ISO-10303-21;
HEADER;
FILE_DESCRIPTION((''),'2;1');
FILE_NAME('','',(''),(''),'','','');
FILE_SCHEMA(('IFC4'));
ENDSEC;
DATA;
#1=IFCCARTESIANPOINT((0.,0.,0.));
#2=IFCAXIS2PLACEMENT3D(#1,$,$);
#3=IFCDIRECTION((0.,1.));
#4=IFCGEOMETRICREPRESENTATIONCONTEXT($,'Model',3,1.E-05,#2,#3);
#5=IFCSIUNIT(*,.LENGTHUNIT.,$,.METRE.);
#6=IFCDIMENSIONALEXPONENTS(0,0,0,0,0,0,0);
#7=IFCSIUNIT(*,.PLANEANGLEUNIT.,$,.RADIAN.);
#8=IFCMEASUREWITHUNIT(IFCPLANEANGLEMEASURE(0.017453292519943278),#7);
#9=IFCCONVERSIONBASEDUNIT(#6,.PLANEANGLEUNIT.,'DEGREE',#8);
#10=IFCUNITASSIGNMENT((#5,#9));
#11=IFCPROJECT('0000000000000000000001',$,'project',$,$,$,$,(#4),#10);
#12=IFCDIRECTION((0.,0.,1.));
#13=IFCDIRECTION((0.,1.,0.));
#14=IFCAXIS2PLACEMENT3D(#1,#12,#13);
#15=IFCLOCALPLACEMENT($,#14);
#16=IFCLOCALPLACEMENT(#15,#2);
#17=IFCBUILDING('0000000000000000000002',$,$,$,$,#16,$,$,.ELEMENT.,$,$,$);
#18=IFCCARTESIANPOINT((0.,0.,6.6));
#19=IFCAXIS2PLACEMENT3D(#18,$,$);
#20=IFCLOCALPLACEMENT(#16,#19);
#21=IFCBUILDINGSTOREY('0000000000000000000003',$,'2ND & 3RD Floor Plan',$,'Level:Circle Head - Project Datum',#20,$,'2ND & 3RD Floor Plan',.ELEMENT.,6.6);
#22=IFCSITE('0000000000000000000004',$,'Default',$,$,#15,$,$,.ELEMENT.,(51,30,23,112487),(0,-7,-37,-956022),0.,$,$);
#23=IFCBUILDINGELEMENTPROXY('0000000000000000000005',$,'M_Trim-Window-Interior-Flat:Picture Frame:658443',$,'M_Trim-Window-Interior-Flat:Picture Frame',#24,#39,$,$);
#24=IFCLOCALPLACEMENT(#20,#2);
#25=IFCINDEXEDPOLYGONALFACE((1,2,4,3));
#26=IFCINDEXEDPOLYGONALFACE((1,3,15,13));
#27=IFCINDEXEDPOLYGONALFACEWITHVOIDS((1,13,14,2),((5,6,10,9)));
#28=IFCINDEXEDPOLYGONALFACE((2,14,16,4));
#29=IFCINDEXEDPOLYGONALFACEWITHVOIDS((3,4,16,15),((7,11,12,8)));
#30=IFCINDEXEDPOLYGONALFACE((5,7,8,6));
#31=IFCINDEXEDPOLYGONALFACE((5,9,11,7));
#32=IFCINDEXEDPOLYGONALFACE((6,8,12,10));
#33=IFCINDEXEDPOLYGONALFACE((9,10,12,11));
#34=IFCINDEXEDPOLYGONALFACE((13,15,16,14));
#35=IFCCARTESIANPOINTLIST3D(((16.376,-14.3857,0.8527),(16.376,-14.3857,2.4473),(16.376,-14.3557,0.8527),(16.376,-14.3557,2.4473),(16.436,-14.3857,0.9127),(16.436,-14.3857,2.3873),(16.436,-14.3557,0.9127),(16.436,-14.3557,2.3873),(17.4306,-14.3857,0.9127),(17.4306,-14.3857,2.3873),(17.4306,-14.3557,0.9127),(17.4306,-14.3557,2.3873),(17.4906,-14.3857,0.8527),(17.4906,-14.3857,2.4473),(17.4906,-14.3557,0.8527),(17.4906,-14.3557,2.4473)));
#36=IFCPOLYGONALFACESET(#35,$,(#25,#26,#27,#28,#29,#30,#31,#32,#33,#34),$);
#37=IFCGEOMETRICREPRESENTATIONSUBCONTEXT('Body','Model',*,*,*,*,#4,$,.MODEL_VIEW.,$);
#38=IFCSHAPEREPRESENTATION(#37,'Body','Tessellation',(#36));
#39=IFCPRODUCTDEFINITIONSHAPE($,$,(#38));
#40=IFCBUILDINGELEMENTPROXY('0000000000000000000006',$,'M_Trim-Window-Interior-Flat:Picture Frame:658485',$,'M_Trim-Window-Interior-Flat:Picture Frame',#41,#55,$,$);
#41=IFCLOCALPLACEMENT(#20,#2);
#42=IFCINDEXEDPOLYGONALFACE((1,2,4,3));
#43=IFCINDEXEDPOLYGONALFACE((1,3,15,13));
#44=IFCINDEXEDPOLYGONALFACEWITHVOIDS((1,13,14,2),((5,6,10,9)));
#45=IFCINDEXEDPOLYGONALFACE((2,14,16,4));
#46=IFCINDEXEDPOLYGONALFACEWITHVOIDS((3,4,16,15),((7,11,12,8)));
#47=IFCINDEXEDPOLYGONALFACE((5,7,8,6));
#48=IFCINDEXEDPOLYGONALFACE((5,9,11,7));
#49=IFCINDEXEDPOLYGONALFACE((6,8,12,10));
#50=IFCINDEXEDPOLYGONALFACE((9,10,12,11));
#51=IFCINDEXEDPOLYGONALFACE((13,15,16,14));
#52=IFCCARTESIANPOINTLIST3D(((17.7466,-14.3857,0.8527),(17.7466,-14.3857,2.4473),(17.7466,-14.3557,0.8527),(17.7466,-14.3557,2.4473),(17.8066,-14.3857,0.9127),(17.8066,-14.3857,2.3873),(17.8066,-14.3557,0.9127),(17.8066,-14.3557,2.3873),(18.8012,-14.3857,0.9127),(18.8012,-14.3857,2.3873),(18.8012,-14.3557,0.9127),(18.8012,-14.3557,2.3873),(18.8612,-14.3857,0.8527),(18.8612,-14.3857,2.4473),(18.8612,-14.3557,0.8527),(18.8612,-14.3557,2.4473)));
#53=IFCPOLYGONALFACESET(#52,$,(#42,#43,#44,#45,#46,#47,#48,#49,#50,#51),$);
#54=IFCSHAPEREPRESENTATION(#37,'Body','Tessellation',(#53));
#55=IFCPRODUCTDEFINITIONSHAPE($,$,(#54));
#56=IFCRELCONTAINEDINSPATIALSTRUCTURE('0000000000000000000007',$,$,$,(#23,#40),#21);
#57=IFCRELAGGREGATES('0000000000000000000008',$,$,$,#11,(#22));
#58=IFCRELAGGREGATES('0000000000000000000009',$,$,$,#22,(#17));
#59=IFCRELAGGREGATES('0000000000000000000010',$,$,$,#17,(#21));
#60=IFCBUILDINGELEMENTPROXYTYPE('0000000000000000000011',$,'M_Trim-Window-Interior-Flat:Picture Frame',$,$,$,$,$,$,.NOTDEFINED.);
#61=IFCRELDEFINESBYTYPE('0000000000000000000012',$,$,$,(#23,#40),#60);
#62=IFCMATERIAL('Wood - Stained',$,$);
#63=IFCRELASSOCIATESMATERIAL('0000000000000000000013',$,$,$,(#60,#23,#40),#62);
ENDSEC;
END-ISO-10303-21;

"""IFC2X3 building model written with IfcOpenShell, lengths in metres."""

from ifc_helpers import new_model, entity, si_unit, converted_unit, direction, frame, origin, place, context, subcontext, project, spatial, polyline, outline, extrude, source, transform, mapped, material, type_object, type_shapes, element, save


model = new_model("IFC2X3")

# Units and contexts
model_context = context("Model", 3, precision=1e-05, world=origin(), true_north=direction((0.0, 1.0)))
body_context = subcontext(model_context, "Body", "Model", "MODEL_VIEW")
ifc_project = project(units=[si_unit("LENGTHUNIT", "METRE"), converted_unit("PLANEANGLEUNIT", "DEGREE", entity("IfcPlaneAngleMeasure", 0.017453292519943278), si_unit("PLANEANGLEUNIT", "RADIAN"), dimensions=[0, 0, 0, 0, 0, 0, 0])], contexts=[model_context])

# Site, building, storey
site_placement = place(None, frame((0.0, 0.0, 0.0), z_axis=(0.0, 0.0, 1.0), x_axis=(0.0, 1.0, 0.0)))
site = spatial("IfcSite", under=ifc_project, at=site_placement, Name="Default", CompositionType="ELEMENT", RefLatitude=(51, 30, 23, 112487), RefLongitude=(0, -7, -37, -956022), RefElevation=0.0)
building_placement = place(site_placement, origin())
building = spatial("IfcBuilding", under=site, at=building_placement, CompositionType="ELEMENT")
storey_placement = place(building_placement, frame((0.0, 0.0, 6.6)))
storey = spatial("IfcBuildingStorey", under=building, at=storey_placement, Name="2ND & 3RD Floor Plan", ObjectType="Level:Circle Head - Project Datum", LongName="2ND & 3RD Floor Plan", CompositionType="ELEMENT", Elevation=6.6)

# Building element proxies
ifc_material_1 = material(Name="Wood - Stained")
building_element_proxy_type_1 = type_object("IfcBuildingElementProxyType", Name="M_Trim-Window-Interior-Flat:Picture Frame", PredefinedType="NOTDEFINED", material=ifc_material_1)
shared_shape_1 = source(origin(), body_context, "Body", "SweptSolid", [
    extrude(outline(polyline([(-0.5573, -0.7973), (0.5573, -0.7973), (0.5573, 0.7973), (-0.5573, 0.7973), (-0.5573, -0.7973)]), holes=[polyline([(-0.4973, -0.7373), (-0.4973, 0.7373), (0.4973, 0.7373), (0.4973, -0.7373), (-0.4973, -0.7373)])]), frame((0.0, -0.75, 0.0), z_axis=(0.0, 0.0, 1.0), x_axis=(-1.0, 0.0, 0.0)), (0.0, 0.0, 1.0), 0.03),
])
type_shapes(building_element_proxy_type_1, [shared_shape_1])
for number, where, z_axis, x_axis, name in (
    (1, (16.9333, -14.3857, 2.4), (0.0, 1.0, 0.0), (-1.0, 0.0, 0.0), "M_Trim-Window-Interior-Flat:Picture Frame:658443"),
    (2, (18.3039, -14.3857, 2.4), (0.0, 1.0, 0.0), (-1.0, 0.0, 0.0), "M_Trim-Window-Interior-Flat:Picture Frame:658485"),
):
    element("IfcBuildingElementProxy", number, at=place(storey_placement, frame(where, z_axis=z_axis, x_axis=x_axis)), inside=storey, type_object=building_element_proxy_type_1, material=ifc_material_1, Name=name, ObjectType="M_Trim-Window-Interior-Flat:Picture Frame", context=body_context, shape_type="MappedRepresentation", body=[
        mapped(shared_shape_1, transform((0.0, 0.0, 0.0), scale=1.0)),
    ])

save(model, "model.ifc")
